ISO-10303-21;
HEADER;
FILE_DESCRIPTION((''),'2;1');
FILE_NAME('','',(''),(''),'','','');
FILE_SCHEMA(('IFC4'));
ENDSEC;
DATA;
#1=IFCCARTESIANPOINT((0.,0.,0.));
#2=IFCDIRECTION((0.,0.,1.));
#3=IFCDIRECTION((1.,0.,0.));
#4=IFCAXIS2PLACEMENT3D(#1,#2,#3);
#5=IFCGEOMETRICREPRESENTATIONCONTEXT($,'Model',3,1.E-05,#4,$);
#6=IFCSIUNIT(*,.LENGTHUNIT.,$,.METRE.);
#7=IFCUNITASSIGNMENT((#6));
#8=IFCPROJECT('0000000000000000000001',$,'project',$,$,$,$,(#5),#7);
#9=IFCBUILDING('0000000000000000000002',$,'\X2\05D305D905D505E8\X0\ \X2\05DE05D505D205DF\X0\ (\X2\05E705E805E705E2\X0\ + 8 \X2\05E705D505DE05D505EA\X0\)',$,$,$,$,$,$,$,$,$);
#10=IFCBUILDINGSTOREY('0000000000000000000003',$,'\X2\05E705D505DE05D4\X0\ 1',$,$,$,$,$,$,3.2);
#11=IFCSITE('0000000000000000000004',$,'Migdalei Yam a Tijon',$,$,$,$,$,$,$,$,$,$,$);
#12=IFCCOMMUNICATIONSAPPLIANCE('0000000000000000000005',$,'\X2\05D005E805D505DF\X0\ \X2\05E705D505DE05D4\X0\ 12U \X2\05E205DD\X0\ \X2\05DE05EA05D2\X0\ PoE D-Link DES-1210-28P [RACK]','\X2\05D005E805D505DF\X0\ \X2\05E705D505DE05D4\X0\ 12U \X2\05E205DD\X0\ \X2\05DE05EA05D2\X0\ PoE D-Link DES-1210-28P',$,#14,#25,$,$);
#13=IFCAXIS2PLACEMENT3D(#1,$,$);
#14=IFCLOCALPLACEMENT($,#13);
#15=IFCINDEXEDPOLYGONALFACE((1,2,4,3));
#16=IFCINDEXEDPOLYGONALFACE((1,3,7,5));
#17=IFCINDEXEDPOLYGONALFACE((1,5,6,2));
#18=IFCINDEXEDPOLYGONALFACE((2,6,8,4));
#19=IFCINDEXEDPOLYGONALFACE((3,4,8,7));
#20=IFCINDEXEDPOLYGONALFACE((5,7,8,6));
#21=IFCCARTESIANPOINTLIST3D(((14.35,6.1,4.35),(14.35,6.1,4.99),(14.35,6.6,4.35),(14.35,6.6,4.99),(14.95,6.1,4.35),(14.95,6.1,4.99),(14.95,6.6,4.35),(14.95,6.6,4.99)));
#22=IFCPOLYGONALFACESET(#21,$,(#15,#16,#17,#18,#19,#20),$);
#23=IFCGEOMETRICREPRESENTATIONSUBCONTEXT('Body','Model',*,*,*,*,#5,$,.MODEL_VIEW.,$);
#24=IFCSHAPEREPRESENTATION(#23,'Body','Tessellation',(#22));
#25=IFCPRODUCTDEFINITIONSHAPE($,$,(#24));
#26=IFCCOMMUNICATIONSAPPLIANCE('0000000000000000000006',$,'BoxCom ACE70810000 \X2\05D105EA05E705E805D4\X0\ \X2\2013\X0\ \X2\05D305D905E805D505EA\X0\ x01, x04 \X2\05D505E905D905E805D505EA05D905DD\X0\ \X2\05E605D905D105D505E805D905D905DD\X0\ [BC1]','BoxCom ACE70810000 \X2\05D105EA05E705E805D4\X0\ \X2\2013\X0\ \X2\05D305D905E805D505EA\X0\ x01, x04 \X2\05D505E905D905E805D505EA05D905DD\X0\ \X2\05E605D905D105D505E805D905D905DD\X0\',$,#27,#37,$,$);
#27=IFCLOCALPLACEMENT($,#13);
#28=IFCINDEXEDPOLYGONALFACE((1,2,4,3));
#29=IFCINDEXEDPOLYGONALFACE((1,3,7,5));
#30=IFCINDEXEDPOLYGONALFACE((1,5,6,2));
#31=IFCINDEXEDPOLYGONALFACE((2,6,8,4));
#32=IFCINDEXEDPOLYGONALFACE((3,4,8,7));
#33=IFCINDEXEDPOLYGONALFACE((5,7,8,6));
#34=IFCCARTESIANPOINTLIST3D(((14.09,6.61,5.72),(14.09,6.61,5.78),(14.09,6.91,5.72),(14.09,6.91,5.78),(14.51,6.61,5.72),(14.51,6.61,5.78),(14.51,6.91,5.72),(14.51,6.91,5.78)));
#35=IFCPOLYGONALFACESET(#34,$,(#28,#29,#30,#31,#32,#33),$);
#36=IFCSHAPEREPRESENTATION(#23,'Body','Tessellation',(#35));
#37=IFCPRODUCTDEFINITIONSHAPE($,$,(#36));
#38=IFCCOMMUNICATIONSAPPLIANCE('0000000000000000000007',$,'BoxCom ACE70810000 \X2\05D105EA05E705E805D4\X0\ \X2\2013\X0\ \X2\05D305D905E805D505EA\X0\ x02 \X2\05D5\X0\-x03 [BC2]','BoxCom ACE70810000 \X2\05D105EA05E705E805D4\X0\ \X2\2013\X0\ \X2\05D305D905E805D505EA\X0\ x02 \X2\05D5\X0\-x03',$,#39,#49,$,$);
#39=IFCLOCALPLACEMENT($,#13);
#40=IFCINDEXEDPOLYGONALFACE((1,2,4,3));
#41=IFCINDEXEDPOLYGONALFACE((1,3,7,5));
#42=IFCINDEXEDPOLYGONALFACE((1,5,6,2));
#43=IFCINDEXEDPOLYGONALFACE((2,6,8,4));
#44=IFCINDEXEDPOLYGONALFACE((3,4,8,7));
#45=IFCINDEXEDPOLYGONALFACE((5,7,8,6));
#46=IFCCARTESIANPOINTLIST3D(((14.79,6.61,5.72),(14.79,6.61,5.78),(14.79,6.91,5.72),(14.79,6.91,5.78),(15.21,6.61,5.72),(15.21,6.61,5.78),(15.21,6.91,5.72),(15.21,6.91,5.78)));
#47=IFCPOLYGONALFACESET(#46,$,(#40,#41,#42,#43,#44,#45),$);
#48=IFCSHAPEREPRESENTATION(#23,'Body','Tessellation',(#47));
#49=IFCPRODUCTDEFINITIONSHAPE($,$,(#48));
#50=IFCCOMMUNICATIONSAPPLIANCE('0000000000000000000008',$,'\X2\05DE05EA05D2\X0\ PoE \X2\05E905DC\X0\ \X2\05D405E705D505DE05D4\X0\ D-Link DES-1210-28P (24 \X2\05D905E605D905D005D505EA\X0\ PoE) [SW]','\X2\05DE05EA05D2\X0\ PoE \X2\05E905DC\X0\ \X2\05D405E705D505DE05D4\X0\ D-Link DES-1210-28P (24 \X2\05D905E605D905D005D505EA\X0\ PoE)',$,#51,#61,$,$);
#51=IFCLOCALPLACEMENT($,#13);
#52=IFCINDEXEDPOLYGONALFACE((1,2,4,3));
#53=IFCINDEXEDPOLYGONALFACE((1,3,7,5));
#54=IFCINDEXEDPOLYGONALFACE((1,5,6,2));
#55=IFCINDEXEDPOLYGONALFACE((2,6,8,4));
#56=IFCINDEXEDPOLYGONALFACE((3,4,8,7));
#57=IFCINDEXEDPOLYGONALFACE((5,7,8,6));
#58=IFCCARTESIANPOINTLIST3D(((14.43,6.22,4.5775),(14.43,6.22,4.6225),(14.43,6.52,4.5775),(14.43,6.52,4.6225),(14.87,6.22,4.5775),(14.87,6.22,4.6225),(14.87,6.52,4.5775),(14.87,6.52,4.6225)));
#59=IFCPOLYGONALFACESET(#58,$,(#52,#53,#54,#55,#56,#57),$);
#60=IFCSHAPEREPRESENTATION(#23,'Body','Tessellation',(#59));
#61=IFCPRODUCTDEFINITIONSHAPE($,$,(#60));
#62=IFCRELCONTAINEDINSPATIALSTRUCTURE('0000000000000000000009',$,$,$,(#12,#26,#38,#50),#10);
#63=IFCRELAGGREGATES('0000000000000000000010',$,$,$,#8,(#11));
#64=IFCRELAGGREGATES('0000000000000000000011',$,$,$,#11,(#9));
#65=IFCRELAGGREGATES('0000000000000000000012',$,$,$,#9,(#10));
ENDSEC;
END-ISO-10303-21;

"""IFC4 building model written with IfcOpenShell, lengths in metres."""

from ifc_helpers import new_model, si_unit, frame, origin_with_axes, context, subcontext, project, spatial, line, indexed_curve, outline, extrude, element, save


model = new_model("IFC4")

# Units and contexts
model_context = context("Model", 3, precision=1e-05, world=origin_with_axes())
body_context = subcontext(model_context, "Body", "Model", "MODEL_VIEW")
ifc_project = project(units=[si_unit("LENGTHUNIT", "METRE")], contexts=[model_context])

# Site, building, storey
site = spatial("IfcSite", under=ifc_project, Name="Migdalei Yam a Tijon")
building = spatial("IfcBuilding", under=site, Name="דיור מוגן (קרקע + 8 קומות)")
storey = spatial("IfcBuildingStorey", under=building, Name="קומה 1", Elevation=3.2)

# Communications appliances
element("IfcCommunicationsAppliance", 1, inside=storey, Name="ארון קומה 12U עם מתג PoE D-Link DES-1210-28P [RACK]", Description="ארון קומה 12U עם מתג PoE D-Link DES-1210-28P", context=body_context, shape_type="SweptSolid", body=[
    extrude(outline(indexed_curve([(0.0, 0.0), (0.6, 0.0), (0.6, 0.5), (0.0, 0.5)], segments=[line(1, 2, 3, 4, 1)])), frame((14.35, 6.1, 4.35), z_axis=(0.0, 0.0, 1.0), x_axis=(1.0, 0.0, 0.0)), (0.0, 0.0, 1.0), 0.64),
])
element("IfcCommunicationsAppliance", 2, inside=storey, Name="BoxCom ACE70810000 בתקרה – דירות x01, x04 ושירותים ציבוריים [BC1]", Description="BoxCom ACE70810000 בתקרה – דירות x01, x04 ושירותים ציבוריים", context=body_context, shape_type="SweptSolid", body=[
    extrude(outline(indexed_curve([(0.0, 0.0), (0.42, 0.0), (0.42, 0.3), (0.0, 0.3)], segments=[line(1, 2, 3, 4, 1)])), frame((14.09, 6.61, 5.72), z_axis=(0.0, 0.0, 1.0), x_axis=(1.0, 0.0, 0.0)), (0.0, 0.0, 1.0), 0.06),
])
element("IfcCommunicationsAppliance", 3, inside=storey, Name="BoxCom ACE70810000 בתקרה – דירות x02 ו-x03 [BC2]", Description="BoxCom ACE70810000 בתקרה – דירות x02 ו-x03", context=body_context, shape_type="SweptSolid", body=[
    extrude(outline(indexed_curve([(0.0, 0.0), (0.42, 0.0), (0.42, 0.3), (0.0, 0.3)], segments=[line(1, 2, 3, 4, 1)])), frame((14.79, 6.61, 5.72), z_axis=(0.0, 0.0, 1.0), x_axis=(1.0, 0.0, 0.0)), (0.0, 0.0, 1.0), 0.06),
])
element("IfcCommunicationsAppliance", 4, inside=storey, Name="מתג PoE של הקומה D-Link DES-1210-28P (24 יציאות PoE) [SW]", Description="מתג PoE של הקומה D-Link DES-1210-28P (24 יציאות PoE)", context=body_context, shape_type="SweptSolid", body=[
    extrude(outline(indexed_curve([(0.0, 0.0), (0.44, 0.0), (0.44, 0.3), (0.0, 0.3)], segments=[line(1, 2, 3, 4, 1)])), frame((14.43, 6.22, 4.5775), z_axis=(0.0, 0.0, 1.0), x_axis=(1.0, 0.0, 0.0)), (0.0, 0.0, 1.0), 0.045),
])

save(model, "model.ifc")
